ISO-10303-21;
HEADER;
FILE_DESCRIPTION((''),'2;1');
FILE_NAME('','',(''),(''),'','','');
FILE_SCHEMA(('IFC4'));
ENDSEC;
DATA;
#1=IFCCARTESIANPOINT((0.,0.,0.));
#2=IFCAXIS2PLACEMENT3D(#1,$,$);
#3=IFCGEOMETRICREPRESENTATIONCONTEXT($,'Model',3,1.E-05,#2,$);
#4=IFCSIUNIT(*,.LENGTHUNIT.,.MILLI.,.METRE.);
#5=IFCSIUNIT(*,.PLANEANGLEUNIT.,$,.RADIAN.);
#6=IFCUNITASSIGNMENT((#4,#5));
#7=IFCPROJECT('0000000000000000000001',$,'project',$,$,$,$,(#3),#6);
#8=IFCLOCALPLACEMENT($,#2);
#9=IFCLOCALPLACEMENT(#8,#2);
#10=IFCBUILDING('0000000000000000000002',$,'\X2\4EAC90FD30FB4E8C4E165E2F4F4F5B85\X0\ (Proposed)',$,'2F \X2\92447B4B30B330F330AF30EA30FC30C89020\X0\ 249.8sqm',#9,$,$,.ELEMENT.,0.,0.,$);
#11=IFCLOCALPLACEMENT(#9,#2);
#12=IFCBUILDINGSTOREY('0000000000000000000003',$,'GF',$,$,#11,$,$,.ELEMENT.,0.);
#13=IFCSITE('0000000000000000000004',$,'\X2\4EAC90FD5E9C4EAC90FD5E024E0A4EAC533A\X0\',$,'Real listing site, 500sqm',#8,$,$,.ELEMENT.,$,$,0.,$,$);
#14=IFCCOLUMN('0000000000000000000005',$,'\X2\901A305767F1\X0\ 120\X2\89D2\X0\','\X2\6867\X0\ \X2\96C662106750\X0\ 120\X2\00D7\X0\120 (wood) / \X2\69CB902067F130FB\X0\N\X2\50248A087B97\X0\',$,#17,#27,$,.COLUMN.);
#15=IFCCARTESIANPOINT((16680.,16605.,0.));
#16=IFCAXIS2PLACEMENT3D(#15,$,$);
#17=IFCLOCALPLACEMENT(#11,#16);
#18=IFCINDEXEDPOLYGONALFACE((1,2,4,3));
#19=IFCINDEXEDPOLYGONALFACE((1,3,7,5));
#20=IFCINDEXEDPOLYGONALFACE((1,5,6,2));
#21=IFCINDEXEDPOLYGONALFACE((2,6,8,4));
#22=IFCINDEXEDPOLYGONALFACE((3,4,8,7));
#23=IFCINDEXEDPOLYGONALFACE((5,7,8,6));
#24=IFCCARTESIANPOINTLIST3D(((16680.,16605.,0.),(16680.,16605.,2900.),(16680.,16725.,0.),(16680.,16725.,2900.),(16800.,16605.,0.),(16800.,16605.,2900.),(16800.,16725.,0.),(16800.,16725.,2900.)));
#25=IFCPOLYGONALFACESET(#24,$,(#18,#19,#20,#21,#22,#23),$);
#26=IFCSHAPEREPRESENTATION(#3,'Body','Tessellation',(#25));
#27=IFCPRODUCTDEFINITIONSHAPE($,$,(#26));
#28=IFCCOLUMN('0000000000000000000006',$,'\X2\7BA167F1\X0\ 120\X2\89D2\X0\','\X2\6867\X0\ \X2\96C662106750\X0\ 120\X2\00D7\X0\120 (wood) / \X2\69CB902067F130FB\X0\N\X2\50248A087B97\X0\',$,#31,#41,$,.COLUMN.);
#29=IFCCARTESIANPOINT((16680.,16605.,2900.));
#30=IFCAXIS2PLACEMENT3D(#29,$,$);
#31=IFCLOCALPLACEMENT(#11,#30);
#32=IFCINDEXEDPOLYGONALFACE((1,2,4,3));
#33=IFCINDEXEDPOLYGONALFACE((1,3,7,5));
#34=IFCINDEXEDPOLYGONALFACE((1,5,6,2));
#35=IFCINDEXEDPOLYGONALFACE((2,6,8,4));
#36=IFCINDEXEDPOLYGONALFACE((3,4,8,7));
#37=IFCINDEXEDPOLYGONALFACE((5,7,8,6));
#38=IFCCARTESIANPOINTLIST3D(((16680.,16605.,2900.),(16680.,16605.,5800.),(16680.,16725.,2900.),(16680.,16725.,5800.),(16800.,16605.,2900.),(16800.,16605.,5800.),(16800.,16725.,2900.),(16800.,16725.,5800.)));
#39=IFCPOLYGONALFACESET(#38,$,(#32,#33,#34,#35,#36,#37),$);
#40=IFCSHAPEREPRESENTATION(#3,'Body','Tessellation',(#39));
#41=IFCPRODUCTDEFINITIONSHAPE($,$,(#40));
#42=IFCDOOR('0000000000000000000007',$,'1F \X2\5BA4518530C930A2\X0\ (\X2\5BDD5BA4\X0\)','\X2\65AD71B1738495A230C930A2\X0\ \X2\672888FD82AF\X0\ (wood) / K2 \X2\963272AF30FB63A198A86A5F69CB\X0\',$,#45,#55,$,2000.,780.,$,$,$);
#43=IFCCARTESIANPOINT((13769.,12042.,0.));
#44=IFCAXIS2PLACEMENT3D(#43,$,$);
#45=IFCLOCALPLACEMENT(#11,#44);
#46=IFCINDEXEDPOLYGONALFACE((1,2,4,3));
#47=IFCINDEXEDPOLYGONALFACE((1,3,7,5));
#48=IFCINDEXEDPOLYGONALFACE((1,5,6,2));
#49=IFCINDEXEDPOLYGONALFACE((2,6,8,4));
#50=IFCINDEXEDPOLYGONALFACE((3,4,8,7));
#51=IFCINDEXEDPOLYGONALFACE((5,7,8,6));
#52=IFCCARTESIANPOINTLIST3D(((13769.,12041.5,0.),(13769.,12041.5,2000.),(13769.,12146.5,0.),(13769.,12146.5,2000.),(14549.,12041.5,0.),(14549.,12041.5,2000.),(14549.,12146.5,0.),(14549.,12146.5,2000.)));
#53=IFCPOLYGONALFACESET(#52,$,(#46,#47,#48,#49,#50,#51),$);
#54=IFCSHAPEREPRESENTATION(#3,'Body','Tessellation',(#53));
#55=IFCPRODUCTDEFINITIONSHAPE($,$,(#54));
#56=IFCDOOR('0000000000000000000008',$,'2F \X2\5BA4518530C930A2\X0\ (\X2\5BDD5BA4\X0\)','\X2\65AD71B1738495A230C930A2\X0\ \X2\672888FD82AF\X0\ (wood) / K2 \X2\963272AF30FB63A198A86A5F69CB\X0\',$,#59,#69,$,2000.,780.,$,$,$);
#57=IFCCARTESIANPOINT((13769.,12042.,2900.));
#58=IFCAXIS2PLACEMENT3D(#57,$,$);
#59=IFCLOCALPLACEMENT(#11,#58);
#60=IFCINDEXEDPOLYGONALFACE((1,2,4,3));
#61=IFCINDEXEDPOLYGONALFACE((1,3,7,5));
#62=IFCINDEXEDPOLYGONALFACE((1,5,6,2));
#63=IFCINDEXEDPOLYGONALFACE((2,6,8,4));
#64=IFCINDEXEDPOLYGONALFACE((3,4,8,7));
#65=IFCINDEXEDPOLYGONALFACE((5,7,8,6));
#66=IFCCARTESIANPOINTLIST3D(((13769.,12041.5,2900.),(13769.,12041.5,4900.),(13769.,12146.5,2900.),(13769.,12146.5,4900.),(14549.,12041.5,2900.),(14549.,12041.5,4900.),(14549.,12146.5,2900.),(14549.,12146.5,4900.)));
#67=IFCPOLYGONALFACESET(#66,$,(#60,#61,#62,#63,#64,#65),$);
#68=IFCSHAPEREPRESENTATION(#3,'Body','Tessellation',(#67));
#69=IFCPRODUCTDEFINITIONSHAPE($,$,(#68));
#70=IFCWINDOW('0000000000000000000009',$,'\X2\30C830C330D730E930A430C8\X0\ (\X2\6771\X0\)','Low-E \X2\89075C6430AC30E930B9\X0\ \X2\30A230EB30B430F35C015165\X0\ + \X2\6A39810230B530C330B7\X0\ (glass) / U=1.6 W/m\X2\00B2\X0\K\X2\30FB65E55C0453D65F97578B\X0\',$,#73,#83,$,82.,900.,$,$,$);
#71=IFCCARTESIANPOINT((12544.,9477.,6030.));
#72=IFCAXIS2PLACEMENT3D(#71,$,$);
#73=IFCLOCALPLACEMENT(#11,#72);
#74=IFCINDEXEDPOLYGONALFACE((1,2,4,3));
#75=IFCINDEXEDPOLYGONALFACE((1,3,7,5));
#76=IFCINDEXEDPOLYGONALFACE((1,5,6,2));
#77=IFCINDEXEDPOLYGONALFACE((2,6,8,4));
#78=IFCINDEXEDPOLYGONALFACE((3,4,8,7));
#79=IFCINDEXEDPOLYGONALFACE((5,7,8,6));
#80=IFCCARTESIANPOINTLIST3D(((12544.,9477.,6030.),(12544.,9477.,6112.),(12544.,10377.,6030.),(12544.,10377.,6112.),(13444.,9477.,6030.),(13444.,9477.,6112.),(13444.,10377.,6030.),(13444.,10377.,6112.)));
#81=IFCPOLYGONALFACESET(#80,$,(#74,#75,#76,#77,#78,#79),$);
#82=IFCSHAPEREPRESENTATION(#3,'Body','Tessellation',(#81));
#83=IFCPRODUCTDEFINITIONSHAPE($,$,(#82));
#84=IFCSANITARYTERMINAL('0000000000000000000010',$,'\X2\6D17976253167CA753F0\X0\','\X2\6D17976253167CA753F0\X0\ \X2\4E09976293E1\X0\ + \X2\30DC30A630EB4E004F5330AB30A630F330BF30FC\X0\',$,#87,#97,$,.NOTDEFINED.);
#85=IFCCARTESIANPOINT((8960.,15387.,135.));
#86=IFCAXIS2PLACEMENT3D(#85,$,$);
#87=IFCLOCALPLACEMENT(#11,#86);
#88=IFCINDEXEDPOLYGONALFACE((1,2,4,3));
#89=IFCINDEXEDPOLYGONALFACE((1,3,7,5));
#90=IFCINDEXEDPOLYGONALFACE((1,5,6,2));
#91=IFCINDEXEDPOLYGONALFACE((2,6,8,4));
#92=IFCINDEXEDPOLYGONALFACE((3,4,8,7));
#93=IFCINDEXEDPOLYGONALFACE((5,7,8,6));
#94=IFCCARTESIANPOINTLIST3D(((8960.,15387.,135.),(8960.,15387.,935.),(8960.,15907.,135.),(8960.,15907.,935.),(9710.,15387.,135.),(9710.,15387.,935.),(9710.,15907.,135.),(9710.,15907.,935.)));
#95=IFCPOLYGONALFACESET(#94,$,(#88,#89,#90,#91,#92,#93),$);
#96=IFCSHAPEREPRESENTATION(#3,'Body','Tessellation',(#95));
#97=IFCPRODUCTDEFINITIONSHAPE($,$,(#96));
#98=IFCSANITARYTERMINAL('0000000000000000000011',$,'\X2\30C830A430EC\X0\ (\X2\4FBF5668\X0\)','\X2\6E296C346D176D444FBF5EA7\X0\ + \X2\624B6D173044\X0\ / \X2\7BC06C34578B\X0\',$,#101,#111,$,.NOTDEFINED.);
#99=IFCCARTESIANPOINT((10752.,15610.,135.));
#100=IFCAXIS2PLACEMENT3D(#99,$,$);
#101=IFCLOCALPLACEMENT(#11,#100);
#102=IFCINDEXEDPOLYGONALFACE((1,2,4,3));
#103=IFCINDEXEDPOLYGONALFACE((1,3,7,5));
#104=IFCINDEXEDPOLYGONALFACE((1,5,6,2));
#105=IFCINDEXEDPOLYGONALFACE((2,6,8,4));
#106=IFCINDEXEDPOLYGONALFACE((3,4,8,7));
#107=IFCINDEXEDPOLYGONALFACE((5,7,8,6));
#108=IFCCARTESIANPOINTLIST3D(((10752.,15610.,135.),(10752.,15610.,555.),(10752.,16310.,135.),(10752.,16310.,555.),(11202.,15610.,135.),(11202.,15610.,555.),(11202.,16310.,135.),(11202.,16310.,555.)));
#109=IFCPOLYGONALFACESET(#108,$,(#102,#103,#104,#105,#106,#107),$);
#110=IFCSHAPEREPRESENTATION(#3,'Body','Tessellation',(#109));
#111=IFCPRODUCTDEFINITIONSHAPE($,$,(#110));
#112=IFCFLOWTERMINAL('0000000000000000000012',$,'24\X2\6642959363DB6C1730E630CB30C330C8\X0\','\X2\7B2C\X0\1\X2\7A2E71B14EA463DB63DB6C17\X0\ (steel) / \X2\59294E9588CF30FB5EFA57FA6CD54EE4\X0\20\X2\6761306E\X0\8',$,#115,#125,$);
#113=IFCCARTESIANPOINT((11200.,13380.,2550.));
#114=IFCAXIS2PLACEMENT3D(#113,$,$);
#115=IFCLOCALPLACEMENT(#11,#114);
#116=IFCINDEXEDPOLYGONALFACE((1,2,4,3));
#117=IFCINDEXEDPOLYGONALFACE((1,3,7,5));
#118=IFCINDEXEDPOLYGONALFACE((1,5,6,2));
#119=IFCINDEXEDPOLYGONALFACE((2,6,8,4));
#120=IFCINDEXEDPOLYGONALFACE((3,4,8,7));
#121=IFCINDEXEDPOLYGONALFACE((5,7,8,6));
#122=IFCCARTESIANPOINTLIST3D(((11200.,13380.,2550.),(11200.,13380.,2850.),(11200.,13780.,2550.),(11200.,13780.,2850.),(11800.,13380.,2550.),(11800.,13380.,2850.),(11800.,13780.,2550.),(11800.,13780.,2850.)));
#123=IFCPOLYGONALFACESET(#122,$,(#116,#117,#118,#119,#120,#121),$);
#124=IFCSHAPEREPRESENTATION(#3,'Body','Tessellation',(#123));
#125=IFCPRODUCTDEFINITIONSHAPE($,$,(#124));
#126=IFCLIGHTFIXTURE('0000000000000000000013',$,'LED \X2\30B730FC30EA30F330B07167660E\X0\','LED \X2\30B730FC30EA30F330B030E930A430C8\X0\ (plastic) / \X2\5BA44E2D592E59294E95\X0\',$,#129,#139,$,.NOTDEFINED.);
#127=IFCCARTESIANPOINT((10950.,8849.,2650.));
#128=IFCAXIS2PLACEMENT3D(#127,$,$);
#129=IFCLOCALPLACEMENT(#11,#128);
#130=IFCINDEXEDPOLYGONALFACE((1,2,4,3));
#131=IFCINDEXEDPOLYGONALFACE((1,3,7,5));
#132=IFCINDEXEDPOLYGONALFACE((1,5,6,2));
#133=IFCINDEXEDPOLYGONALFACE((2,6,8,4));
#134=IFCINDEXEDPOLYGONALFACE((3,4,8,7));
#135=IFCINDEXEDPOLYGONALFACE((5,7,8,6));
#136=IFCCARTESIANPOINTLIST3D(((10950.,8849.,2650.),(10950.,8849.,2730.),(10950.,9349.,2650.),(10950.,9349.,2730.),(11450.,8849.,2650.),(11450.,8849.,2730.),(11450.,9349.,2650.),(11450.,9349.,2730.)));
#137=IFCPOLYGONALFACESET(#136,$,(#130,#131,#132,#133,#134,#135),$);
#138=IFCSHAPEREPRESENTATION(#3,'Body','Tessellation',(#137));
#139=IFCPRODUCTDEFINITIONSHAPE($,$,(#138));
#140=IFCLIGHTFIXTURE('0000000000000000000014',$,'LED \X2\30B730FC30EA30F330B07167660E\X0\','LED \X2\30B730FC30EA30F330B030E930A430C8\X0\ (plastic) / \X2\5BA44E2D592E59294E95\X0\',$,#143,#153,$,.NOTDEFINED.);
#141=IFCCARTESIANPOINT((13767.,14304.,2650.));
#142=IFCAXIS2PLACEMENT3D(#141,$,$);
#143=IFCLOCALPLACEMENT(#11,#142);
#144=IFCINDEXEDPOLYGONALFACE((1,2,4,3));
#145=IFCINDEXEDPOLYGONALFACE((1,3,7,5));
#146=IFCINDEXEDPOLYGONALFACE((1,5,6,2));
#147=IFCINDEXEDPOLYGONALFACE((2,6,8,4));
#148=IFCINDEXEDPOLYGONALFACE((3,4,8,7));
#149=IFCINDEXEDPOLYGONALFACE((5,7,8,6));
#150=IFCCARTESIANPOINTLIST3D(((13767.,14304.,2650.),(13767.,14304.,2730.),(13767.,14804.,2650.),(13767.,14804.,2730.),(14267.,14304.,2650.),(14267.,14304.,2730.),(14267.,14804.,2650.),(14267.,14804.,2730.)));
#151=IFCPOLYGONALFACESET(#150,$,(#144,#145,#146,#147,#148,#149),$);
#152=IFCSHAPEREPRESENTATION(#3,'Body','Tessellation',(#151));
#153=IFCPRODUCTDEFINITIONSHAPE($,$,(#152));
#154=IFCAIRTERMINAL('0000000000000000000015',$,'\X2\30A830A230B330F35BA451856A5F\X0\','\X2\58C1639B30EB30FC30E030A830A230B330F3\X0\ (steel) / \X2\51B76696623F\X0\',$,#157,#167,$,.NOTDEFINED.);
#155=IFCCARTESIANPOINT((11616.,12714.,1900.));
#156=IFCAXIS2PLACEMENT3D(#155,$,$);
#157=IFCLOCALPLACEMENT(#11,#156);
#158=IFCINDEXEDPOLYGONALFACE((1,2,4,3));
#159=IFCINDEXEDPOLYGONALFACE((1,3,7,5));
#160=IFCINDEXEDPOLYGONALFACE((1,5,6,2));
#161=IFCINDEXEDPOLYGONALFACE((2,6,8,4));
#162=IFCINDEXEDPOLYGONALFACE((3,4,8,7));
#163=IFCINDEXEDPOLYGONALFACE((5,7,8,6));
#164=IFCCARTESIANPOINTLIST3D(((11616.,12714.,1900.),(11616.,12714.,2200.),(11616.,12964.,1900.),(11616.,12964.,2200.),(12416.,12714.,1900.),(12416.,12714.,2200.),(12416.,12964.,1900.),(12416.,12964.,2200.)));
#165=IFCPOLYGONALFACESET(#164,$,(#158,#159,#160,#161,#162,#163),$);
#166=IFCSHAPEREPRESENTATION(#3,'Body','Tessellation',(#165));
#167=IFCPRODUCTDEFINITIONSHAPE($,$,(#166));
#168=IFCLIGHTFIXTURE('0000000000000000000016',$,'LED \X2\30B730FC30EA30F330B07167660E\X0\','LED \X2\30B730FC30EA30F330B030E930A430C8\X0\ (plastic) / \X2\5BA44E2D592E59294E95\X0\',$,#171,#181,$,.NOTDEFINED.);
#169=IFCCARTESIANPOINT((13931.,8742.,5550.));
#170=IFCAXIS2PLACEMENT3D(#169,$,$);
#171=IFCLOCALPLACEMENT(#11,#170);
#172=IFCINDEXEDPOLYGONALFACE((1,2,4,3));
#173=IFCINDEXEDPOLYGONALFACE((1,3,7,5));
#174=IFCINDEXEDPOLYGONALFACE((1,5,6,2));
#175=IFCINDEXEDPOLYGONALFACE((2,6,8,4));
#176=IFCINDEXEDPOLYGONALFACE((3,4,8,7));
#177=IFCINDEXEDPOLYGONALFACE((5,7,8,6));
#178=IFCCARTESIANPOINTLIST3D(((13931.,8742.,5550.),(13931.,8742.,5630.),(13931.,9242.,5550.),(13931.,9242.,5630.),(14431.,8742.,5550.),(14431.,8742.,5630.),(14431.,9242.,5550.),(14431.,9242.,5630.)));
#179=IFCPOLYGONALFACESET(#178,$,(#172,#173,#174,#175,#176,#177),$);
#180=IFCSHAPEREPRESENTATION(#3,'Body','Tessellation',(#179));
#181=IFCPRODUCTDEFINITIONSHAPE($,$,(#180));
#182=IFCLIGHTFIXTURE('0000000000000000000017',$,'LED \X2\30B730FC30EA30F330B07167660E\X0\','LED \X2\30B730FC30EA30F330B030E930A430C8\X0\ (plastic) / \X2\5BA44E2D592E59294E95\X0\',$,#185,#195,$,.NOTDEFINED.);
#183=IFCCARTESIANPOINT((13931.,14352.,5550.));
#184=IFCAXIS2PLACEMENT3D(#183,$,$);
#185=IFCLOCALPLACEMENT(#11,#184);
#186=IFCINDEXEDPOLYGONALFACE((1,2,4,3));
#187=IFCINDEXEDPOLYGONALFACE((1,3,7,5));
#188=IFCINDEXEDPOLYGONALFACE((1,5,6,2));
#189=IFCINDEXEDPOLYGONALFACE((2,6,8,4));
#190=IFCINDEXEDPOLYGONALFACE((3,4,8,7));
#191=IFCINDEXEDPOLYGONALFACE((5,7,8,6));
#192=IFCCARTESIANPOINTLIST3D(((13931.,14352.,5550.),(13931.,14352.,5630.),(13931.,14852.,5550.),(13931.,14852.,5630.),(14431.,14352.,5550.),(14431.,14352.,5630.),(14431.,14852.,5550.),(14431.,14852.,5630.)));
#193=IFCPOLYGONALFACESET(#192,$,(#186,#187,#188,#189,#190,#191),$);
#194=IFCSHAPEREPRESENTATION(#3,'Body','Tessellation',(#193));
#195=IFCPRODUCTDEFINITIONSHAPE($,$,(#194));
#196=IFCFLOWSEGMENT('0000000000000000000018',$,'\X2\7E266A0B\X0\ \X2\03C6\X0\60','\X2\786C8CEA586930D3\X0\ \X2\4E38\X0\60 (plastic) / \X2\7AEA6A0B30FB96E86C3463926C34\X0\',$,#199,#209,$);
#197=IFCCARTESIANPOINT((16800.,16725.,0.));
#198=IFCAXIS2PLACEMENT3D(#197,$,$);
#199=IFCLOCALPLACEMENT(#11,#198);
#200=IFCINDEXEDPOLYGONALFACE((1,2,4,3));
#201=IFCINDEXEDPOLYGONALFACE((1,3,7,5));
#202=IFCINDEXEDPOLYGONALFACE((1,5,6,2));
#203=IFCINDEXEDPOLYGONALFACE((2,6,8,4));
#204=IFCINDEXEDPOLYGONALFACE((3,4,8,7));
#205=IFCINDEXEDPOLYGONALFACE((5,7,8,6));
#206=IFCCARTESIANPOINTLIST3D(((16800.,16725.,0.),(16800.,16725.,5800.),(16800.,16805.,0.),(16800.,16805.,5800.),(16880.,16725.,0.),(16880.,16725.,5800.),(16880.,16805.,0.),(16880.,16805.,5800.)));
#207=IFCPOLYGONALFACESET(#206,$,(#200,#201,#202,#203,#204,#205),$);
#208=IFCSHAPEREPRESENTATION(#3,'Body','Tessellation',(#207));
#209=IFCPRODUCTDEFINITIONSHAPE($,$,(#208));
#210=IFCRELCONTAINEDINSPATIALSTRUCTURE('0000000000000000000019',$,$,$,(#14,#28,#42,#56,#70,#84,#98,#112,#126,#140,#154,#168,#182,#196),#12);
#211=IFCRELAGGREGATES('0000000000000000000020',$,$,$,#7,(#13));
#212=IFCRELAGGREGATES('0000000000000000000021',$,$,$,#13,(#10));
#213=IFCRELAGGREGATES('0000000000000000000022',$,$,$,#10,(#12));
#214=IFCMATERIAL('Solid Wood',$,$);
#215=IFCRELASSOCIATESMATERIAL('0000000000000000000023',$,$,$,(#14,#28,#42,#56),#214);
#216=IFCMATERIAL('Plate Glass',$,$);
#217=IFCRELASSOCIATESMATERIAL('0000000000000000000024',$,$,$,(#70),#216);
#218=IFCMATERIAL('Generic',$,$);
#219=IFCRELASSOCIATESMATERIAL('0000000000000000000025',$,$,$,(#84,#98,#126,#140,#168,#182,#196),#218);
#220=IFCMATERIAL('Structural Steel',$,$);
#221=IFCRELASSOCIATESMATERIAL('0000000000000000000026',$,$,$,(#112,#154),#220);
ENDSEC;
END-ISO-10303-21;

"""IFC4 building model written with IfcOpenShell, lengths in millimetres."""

from ifc_helpers import new_model, si_unit, frame, frame_2d, origin, place, context, project, spatial, rectangle, extrude, material, element, save


model = new_model("IFC4")

# Units and contexts
model_context = context("Model", 3, precision=1e-05, world=origin())
ifc_project = project(units=[si_unit("LENGTHUNIT", "METRE", prefix="MILLI"), si_unit("PLANEANGLEUNIT", "RADIAN")], contexts=[model_context])

# Site, building, storey
site_placement = place(None, origin())
site = spatial("IfcSite", under=ifc_project, at=site_placement, Name="京都府京都市上京区", ObjectType="Real listing site, 500sqm", CompositionType="ELEMENT", RefElevation=0.0)
building_placement = place(site_placement, origin())
building = spatial("IfcBuilding", under=site, at=building_placement, Name="京都・二世帯住宅 (Proposed)", ObjectType="2F 鉄筋コンクリート造 249.8sqm", CompositionType="ELEMENT", ElevationOfRefHeight=0.0, ElevationOfTerrain=0.0)
storey_placement = place(building_placement, origin())
storey = spatial("IfcBuildingStorey", under=building, at=storey_placement, Name="GF", CompositionType="ELEMENT", Elevation=0.0)

# Columns
ifc_material_1 = material(Name="Solid Wood")
column_1_placement = place(storey_placement, frame((16680.0, 16605.0, 0.0)))
element("IfcColumn", 1, at=column_1_placement, inside=storey, material=ifc_material_1, Name="通し柱 120角", Description="桧 集成材 120×120 (wood) / 構造柱・N値計算", PredefinedType="COLUMN", context=model_context, shape_type="SweptSolid", body=[
    extrude(rectangle(XDim=120.0, YDim=120.0, at=frame_2d((60.0, 60.0))), frame((16680.0, 16605.0, 0.0)), (0.0, 0.0, 1.0), 2900.0),
])
column_2_placement = place(storey_placement, frame((16680.0, 16605.0, 2900.0)))
element("IfcColumn", 2, at=column_2_placement, inside=storey, material=ifc_material_1, Name="管柱 120角", Description="桧 集成材 120×120 (wood) / 構造柱・N値計算", PredefinedType="COLUMN", context=model_context, shape_type="SweptSolid", body=[
    extrude(rectangle(XDim=120.0, YDim=120.0, at=frame_2d((60.0, 60.0))), frame((16680.0, 16605.0, 2900.0)), (0.0, 0.0, 1.0), 2900.0),
])

# Door
door_1_placement = place(storey_placement, frame((13769.0, 12042.0, 0.0)))
element("IfcDoor", 3, at=door_1_placement, inside=storey, material=ifc_material_1, Name="1F 室内ドア (寝室)", Description="断熱玄関ドア 木製芯 (wood) / K2 防犯・採風機構", OverallHeight=2000.0, OverallWidth=780.0, context=model_context, shape_type="SweptSolid", body=[
    extrude(rectangle(XDim=780.0, YDim=105.0, at=frame_2d((390.0, 52.0))), frame((13769.0, 12042.0, 0.0)), (0.0, 0.0, 1.0), 2000.0),
])

# Door
door_2_placement = place(storey_placement, frame((13769.0, 12042.0, 2900.0)))
element("IfcDoor", 4, at=door_2_placement, inside=storey, material=ifc_material_1, Name="2F 室内ドア (寝室)", Description="断熱玄関ドア 木製芯 (wood) / K2 防犯・採風機構", OverallHeight=2000.0, OverallWidth=780.0, context=model_context, shape_type="SweptSolid", body=[
    extrude(rectangle(XDim=780.0, YDim=105.0, at=frame_2d((390.0, 52.0))), frame((13769.0, 12042.0, 2900.0)), (0.0, 0.0, 1.0), 2000.0),
])

# Window
ifc_material_2 = material(Name="Plate Glass")
window_placement = place(storey_placement, frame((12544.0, 9477.0, 6030.0)))
element("IfcWindow", 5, at=window_placement, inside=storey, material=ifc_material_2, Name="トップライト (東)", Description="Low-E 複層ガラス アルゴン封入 + 樹脂サッシ (glass) / U=1.6 W/m²K・日射取得型", OverallHeight=82.0, OverallWidth=900.0, context=model_context, shape_type="SweptSolid", body=[
    extrude(rectangle(XDim=900.0, YDim=900.0, at=frame_2d((450.0, 450.0))), frame((12544.0, 9477.0, 6030.0)), (0.0, 0.0, 1.0), 82.0),
])

# Sanitary terminals
ifc_material_3 = material(Name="Generic")
sanitary_terminal_1_placement = place(storey_placement, frame((8960.0, 15387.0, 135.0)))
element("IfcSanitaryTerminal", 6, at=sanitary_terminal_1_placement, inside=storey, material=ifc_material_3, Name="洗面化粧台", Description="洗面化粧台 三面鏡 + ボウル一体カウンター", PredefinedType="NOTDEFINED", context=model_context, shape_type="SweptSolid", body=[
    extrude(rectangle(XDim=750.0, YDim=520.0, at=frame_2d((375.0, 260.0))), frame((8960.0, 15387.0, 135.0)), (0.0, 0.0, 1.0), 800.0),
])
sanitary_terminal_2_placement = place(storey_placement, frame((10752.0, 15610.0, 135.0)))
element("IfcSanitaryTerminal", 7, at=sanitary_terminal_2_placement, inside=storey, material=ifc_material_3, Name="トイレ (便器)", Description="温水洗浄便座 + 手洗い / 節水型", PredefinedType="NOTDEFINED", context=model_context, shape_type="SweptSolid", body=[
    extrude(rectangle(XDim=450.0, YDim=700.0, at=frame_2d((225.0, 350.0))), frame((10752.0, 15610.0, 135.0)), (0.0, 0.0, 1.0), 420.0),
])

# Flow terminal
ifc_material_4 = material(Name="Structural Steel")
flow_terminal_placement = place(storey_placement, frame((11200.0, 13380.0, 2550.0)))
element("IfcFlowTerminal", 8, at=flow_terminal_placement, inside=storey, material=ifc_material_4, Name="24時間換気ユニット", Description="第1種熱交換換気 (steel) / 天井裏・建基法令20条の8", context=model_context, shape_type="SweptSolid", body=[
    extrude(rectangle(XDim=600.0, YDim=400.0, at=frame_2d((300.0, 200.0))), frame((11200.0, 13380.0, 2550.0)), (0.0, 0.0, 1.0), 300.0),
])

# Light fixtures
light_fixture_1_placement = place(storey_placement, frame((10950.0, 8849.0, 2650.0)))
element("IfcLightFixture", 9, at=light_fixture_1_placement, inside=storey, material=ifc_material_3, Name="LED シーリング照明", Description="LED シーリングライト (plastic) / 室中央天井", PredefinedType="NOTDEFINED", context=model_context, shape_type="SweptSolid", body=[
    extrude(rectangle(XDim=500.0, YDim=500.0, at=frame_2d((250.0, 250.0))), frame((10950.0, 8849.0, 2650.0)), (0.0, 0.0, 1.0), 80.0),
])
light_fixture_2_placement = place(storey_placement, frame((13767.0, 14304.0, 2650.0)))
element("IfcLightFixture", 10, at=light_fixture_2_placement, inside=storey, material=ifc_material_3, Name="LED シーリング照明", Description="LED シーリングライト (plastic) / 室中央天井", PredefinedType="NOTDEFINED", context=model_context, shape_type="SweptSolid", body=[
    extrude(rectangle(XDim=500.0, YDim=500.0, at=frame_2d((250.0, 250.0))), frame((13767.0, 14304.0, 2650.0)), (0.0, 0.0, 1.0), 80.0),
])

# Air terminal
air_terminal_placement = place(storey_placement, frame((11616.0, 12714.0, 1900.0)))
element("IfcAirTerminal", 11, at=air_terminal_placement, inside=storey, material=ifc_material_4, Name="エアコン室内機", Description="壁掛ルームエアコン (steel) / 冷暖房", PredefinedType="NOTDEFINED", context=model_context, shape_type="SweptSolid", body=[
    extrude(rectangle(XDim=800.0, YDim=250.0, at=frame_2d((400.0, 125.0))), frame((11616.0, 12714.0, 1900.0)), (0.0, 0.0, 1.0), 300.0),
])

# Light fixtures
light_fixture_3_placement = place(storey_placement, frame((13931.0, 8742.0, 5550.0)))
element("IfcLightFixture", 12, at=light_fixture_3_placement, inside=storey, material=ifc_material_3, Name="LED シーリング照明", Description="LED シーリングライト (plastic) / 室中央天井", PredefinedType="NOTDEFINED", context=model_context, shape_type="SweptSolid", body=[
    extrude(rectangle(XDim=500.0, YDim=500.0, at=frame_2d((250.0, 250.0))), frame((13931.0, 8742.0, 5550.0)), (0.0, 0.0, 1.0), 80.0),
])
light_fixture_4_placement = place(storey_placement, frame((13931.0, 14352.0, 5550.0)))
element("IfcLightFixture", 13, at=light_fixture_4_placement, inside=storey, material=ifc_material_3, Name="LED シーリング照明", Description="LED シーリングライト (plastic) / 室中央天井", PredefinedType="NOTDEFINED", context=model_context, shape_type="SweptSolid", body=[
    extrude(rectangle(XDim=500.0, YDim=500.0, at=frame_2d((250.0, 250.0))), frame((13931.0, 14352.0, 5550.0)), (0.0, 0.0, 1.0), 80.0),
])

# Flow segment
flow_segment_placement = place(storey_placement, frame((16800.0, 16725.0, 0.0)))
element("IfcFlowSegment", 14, at=flow_segment_placement, inside=storey, material=ifc_material_3, Name="縦樋 φ60", Description="硬質塩ビ 丸60 (plastic) / 竪樋・雨水排水", context=model_context, shape_type="SweptSolid", body=[
    extrude(rectangle(XDim=80.0, YDim=80.0, at=frame_2d((40.0, 40.0))), frame((16800.0, 16725.0, 0.0)), (0.0, 0.0, 1.0), 5800.0),
])

save(model, "model.ifc")
